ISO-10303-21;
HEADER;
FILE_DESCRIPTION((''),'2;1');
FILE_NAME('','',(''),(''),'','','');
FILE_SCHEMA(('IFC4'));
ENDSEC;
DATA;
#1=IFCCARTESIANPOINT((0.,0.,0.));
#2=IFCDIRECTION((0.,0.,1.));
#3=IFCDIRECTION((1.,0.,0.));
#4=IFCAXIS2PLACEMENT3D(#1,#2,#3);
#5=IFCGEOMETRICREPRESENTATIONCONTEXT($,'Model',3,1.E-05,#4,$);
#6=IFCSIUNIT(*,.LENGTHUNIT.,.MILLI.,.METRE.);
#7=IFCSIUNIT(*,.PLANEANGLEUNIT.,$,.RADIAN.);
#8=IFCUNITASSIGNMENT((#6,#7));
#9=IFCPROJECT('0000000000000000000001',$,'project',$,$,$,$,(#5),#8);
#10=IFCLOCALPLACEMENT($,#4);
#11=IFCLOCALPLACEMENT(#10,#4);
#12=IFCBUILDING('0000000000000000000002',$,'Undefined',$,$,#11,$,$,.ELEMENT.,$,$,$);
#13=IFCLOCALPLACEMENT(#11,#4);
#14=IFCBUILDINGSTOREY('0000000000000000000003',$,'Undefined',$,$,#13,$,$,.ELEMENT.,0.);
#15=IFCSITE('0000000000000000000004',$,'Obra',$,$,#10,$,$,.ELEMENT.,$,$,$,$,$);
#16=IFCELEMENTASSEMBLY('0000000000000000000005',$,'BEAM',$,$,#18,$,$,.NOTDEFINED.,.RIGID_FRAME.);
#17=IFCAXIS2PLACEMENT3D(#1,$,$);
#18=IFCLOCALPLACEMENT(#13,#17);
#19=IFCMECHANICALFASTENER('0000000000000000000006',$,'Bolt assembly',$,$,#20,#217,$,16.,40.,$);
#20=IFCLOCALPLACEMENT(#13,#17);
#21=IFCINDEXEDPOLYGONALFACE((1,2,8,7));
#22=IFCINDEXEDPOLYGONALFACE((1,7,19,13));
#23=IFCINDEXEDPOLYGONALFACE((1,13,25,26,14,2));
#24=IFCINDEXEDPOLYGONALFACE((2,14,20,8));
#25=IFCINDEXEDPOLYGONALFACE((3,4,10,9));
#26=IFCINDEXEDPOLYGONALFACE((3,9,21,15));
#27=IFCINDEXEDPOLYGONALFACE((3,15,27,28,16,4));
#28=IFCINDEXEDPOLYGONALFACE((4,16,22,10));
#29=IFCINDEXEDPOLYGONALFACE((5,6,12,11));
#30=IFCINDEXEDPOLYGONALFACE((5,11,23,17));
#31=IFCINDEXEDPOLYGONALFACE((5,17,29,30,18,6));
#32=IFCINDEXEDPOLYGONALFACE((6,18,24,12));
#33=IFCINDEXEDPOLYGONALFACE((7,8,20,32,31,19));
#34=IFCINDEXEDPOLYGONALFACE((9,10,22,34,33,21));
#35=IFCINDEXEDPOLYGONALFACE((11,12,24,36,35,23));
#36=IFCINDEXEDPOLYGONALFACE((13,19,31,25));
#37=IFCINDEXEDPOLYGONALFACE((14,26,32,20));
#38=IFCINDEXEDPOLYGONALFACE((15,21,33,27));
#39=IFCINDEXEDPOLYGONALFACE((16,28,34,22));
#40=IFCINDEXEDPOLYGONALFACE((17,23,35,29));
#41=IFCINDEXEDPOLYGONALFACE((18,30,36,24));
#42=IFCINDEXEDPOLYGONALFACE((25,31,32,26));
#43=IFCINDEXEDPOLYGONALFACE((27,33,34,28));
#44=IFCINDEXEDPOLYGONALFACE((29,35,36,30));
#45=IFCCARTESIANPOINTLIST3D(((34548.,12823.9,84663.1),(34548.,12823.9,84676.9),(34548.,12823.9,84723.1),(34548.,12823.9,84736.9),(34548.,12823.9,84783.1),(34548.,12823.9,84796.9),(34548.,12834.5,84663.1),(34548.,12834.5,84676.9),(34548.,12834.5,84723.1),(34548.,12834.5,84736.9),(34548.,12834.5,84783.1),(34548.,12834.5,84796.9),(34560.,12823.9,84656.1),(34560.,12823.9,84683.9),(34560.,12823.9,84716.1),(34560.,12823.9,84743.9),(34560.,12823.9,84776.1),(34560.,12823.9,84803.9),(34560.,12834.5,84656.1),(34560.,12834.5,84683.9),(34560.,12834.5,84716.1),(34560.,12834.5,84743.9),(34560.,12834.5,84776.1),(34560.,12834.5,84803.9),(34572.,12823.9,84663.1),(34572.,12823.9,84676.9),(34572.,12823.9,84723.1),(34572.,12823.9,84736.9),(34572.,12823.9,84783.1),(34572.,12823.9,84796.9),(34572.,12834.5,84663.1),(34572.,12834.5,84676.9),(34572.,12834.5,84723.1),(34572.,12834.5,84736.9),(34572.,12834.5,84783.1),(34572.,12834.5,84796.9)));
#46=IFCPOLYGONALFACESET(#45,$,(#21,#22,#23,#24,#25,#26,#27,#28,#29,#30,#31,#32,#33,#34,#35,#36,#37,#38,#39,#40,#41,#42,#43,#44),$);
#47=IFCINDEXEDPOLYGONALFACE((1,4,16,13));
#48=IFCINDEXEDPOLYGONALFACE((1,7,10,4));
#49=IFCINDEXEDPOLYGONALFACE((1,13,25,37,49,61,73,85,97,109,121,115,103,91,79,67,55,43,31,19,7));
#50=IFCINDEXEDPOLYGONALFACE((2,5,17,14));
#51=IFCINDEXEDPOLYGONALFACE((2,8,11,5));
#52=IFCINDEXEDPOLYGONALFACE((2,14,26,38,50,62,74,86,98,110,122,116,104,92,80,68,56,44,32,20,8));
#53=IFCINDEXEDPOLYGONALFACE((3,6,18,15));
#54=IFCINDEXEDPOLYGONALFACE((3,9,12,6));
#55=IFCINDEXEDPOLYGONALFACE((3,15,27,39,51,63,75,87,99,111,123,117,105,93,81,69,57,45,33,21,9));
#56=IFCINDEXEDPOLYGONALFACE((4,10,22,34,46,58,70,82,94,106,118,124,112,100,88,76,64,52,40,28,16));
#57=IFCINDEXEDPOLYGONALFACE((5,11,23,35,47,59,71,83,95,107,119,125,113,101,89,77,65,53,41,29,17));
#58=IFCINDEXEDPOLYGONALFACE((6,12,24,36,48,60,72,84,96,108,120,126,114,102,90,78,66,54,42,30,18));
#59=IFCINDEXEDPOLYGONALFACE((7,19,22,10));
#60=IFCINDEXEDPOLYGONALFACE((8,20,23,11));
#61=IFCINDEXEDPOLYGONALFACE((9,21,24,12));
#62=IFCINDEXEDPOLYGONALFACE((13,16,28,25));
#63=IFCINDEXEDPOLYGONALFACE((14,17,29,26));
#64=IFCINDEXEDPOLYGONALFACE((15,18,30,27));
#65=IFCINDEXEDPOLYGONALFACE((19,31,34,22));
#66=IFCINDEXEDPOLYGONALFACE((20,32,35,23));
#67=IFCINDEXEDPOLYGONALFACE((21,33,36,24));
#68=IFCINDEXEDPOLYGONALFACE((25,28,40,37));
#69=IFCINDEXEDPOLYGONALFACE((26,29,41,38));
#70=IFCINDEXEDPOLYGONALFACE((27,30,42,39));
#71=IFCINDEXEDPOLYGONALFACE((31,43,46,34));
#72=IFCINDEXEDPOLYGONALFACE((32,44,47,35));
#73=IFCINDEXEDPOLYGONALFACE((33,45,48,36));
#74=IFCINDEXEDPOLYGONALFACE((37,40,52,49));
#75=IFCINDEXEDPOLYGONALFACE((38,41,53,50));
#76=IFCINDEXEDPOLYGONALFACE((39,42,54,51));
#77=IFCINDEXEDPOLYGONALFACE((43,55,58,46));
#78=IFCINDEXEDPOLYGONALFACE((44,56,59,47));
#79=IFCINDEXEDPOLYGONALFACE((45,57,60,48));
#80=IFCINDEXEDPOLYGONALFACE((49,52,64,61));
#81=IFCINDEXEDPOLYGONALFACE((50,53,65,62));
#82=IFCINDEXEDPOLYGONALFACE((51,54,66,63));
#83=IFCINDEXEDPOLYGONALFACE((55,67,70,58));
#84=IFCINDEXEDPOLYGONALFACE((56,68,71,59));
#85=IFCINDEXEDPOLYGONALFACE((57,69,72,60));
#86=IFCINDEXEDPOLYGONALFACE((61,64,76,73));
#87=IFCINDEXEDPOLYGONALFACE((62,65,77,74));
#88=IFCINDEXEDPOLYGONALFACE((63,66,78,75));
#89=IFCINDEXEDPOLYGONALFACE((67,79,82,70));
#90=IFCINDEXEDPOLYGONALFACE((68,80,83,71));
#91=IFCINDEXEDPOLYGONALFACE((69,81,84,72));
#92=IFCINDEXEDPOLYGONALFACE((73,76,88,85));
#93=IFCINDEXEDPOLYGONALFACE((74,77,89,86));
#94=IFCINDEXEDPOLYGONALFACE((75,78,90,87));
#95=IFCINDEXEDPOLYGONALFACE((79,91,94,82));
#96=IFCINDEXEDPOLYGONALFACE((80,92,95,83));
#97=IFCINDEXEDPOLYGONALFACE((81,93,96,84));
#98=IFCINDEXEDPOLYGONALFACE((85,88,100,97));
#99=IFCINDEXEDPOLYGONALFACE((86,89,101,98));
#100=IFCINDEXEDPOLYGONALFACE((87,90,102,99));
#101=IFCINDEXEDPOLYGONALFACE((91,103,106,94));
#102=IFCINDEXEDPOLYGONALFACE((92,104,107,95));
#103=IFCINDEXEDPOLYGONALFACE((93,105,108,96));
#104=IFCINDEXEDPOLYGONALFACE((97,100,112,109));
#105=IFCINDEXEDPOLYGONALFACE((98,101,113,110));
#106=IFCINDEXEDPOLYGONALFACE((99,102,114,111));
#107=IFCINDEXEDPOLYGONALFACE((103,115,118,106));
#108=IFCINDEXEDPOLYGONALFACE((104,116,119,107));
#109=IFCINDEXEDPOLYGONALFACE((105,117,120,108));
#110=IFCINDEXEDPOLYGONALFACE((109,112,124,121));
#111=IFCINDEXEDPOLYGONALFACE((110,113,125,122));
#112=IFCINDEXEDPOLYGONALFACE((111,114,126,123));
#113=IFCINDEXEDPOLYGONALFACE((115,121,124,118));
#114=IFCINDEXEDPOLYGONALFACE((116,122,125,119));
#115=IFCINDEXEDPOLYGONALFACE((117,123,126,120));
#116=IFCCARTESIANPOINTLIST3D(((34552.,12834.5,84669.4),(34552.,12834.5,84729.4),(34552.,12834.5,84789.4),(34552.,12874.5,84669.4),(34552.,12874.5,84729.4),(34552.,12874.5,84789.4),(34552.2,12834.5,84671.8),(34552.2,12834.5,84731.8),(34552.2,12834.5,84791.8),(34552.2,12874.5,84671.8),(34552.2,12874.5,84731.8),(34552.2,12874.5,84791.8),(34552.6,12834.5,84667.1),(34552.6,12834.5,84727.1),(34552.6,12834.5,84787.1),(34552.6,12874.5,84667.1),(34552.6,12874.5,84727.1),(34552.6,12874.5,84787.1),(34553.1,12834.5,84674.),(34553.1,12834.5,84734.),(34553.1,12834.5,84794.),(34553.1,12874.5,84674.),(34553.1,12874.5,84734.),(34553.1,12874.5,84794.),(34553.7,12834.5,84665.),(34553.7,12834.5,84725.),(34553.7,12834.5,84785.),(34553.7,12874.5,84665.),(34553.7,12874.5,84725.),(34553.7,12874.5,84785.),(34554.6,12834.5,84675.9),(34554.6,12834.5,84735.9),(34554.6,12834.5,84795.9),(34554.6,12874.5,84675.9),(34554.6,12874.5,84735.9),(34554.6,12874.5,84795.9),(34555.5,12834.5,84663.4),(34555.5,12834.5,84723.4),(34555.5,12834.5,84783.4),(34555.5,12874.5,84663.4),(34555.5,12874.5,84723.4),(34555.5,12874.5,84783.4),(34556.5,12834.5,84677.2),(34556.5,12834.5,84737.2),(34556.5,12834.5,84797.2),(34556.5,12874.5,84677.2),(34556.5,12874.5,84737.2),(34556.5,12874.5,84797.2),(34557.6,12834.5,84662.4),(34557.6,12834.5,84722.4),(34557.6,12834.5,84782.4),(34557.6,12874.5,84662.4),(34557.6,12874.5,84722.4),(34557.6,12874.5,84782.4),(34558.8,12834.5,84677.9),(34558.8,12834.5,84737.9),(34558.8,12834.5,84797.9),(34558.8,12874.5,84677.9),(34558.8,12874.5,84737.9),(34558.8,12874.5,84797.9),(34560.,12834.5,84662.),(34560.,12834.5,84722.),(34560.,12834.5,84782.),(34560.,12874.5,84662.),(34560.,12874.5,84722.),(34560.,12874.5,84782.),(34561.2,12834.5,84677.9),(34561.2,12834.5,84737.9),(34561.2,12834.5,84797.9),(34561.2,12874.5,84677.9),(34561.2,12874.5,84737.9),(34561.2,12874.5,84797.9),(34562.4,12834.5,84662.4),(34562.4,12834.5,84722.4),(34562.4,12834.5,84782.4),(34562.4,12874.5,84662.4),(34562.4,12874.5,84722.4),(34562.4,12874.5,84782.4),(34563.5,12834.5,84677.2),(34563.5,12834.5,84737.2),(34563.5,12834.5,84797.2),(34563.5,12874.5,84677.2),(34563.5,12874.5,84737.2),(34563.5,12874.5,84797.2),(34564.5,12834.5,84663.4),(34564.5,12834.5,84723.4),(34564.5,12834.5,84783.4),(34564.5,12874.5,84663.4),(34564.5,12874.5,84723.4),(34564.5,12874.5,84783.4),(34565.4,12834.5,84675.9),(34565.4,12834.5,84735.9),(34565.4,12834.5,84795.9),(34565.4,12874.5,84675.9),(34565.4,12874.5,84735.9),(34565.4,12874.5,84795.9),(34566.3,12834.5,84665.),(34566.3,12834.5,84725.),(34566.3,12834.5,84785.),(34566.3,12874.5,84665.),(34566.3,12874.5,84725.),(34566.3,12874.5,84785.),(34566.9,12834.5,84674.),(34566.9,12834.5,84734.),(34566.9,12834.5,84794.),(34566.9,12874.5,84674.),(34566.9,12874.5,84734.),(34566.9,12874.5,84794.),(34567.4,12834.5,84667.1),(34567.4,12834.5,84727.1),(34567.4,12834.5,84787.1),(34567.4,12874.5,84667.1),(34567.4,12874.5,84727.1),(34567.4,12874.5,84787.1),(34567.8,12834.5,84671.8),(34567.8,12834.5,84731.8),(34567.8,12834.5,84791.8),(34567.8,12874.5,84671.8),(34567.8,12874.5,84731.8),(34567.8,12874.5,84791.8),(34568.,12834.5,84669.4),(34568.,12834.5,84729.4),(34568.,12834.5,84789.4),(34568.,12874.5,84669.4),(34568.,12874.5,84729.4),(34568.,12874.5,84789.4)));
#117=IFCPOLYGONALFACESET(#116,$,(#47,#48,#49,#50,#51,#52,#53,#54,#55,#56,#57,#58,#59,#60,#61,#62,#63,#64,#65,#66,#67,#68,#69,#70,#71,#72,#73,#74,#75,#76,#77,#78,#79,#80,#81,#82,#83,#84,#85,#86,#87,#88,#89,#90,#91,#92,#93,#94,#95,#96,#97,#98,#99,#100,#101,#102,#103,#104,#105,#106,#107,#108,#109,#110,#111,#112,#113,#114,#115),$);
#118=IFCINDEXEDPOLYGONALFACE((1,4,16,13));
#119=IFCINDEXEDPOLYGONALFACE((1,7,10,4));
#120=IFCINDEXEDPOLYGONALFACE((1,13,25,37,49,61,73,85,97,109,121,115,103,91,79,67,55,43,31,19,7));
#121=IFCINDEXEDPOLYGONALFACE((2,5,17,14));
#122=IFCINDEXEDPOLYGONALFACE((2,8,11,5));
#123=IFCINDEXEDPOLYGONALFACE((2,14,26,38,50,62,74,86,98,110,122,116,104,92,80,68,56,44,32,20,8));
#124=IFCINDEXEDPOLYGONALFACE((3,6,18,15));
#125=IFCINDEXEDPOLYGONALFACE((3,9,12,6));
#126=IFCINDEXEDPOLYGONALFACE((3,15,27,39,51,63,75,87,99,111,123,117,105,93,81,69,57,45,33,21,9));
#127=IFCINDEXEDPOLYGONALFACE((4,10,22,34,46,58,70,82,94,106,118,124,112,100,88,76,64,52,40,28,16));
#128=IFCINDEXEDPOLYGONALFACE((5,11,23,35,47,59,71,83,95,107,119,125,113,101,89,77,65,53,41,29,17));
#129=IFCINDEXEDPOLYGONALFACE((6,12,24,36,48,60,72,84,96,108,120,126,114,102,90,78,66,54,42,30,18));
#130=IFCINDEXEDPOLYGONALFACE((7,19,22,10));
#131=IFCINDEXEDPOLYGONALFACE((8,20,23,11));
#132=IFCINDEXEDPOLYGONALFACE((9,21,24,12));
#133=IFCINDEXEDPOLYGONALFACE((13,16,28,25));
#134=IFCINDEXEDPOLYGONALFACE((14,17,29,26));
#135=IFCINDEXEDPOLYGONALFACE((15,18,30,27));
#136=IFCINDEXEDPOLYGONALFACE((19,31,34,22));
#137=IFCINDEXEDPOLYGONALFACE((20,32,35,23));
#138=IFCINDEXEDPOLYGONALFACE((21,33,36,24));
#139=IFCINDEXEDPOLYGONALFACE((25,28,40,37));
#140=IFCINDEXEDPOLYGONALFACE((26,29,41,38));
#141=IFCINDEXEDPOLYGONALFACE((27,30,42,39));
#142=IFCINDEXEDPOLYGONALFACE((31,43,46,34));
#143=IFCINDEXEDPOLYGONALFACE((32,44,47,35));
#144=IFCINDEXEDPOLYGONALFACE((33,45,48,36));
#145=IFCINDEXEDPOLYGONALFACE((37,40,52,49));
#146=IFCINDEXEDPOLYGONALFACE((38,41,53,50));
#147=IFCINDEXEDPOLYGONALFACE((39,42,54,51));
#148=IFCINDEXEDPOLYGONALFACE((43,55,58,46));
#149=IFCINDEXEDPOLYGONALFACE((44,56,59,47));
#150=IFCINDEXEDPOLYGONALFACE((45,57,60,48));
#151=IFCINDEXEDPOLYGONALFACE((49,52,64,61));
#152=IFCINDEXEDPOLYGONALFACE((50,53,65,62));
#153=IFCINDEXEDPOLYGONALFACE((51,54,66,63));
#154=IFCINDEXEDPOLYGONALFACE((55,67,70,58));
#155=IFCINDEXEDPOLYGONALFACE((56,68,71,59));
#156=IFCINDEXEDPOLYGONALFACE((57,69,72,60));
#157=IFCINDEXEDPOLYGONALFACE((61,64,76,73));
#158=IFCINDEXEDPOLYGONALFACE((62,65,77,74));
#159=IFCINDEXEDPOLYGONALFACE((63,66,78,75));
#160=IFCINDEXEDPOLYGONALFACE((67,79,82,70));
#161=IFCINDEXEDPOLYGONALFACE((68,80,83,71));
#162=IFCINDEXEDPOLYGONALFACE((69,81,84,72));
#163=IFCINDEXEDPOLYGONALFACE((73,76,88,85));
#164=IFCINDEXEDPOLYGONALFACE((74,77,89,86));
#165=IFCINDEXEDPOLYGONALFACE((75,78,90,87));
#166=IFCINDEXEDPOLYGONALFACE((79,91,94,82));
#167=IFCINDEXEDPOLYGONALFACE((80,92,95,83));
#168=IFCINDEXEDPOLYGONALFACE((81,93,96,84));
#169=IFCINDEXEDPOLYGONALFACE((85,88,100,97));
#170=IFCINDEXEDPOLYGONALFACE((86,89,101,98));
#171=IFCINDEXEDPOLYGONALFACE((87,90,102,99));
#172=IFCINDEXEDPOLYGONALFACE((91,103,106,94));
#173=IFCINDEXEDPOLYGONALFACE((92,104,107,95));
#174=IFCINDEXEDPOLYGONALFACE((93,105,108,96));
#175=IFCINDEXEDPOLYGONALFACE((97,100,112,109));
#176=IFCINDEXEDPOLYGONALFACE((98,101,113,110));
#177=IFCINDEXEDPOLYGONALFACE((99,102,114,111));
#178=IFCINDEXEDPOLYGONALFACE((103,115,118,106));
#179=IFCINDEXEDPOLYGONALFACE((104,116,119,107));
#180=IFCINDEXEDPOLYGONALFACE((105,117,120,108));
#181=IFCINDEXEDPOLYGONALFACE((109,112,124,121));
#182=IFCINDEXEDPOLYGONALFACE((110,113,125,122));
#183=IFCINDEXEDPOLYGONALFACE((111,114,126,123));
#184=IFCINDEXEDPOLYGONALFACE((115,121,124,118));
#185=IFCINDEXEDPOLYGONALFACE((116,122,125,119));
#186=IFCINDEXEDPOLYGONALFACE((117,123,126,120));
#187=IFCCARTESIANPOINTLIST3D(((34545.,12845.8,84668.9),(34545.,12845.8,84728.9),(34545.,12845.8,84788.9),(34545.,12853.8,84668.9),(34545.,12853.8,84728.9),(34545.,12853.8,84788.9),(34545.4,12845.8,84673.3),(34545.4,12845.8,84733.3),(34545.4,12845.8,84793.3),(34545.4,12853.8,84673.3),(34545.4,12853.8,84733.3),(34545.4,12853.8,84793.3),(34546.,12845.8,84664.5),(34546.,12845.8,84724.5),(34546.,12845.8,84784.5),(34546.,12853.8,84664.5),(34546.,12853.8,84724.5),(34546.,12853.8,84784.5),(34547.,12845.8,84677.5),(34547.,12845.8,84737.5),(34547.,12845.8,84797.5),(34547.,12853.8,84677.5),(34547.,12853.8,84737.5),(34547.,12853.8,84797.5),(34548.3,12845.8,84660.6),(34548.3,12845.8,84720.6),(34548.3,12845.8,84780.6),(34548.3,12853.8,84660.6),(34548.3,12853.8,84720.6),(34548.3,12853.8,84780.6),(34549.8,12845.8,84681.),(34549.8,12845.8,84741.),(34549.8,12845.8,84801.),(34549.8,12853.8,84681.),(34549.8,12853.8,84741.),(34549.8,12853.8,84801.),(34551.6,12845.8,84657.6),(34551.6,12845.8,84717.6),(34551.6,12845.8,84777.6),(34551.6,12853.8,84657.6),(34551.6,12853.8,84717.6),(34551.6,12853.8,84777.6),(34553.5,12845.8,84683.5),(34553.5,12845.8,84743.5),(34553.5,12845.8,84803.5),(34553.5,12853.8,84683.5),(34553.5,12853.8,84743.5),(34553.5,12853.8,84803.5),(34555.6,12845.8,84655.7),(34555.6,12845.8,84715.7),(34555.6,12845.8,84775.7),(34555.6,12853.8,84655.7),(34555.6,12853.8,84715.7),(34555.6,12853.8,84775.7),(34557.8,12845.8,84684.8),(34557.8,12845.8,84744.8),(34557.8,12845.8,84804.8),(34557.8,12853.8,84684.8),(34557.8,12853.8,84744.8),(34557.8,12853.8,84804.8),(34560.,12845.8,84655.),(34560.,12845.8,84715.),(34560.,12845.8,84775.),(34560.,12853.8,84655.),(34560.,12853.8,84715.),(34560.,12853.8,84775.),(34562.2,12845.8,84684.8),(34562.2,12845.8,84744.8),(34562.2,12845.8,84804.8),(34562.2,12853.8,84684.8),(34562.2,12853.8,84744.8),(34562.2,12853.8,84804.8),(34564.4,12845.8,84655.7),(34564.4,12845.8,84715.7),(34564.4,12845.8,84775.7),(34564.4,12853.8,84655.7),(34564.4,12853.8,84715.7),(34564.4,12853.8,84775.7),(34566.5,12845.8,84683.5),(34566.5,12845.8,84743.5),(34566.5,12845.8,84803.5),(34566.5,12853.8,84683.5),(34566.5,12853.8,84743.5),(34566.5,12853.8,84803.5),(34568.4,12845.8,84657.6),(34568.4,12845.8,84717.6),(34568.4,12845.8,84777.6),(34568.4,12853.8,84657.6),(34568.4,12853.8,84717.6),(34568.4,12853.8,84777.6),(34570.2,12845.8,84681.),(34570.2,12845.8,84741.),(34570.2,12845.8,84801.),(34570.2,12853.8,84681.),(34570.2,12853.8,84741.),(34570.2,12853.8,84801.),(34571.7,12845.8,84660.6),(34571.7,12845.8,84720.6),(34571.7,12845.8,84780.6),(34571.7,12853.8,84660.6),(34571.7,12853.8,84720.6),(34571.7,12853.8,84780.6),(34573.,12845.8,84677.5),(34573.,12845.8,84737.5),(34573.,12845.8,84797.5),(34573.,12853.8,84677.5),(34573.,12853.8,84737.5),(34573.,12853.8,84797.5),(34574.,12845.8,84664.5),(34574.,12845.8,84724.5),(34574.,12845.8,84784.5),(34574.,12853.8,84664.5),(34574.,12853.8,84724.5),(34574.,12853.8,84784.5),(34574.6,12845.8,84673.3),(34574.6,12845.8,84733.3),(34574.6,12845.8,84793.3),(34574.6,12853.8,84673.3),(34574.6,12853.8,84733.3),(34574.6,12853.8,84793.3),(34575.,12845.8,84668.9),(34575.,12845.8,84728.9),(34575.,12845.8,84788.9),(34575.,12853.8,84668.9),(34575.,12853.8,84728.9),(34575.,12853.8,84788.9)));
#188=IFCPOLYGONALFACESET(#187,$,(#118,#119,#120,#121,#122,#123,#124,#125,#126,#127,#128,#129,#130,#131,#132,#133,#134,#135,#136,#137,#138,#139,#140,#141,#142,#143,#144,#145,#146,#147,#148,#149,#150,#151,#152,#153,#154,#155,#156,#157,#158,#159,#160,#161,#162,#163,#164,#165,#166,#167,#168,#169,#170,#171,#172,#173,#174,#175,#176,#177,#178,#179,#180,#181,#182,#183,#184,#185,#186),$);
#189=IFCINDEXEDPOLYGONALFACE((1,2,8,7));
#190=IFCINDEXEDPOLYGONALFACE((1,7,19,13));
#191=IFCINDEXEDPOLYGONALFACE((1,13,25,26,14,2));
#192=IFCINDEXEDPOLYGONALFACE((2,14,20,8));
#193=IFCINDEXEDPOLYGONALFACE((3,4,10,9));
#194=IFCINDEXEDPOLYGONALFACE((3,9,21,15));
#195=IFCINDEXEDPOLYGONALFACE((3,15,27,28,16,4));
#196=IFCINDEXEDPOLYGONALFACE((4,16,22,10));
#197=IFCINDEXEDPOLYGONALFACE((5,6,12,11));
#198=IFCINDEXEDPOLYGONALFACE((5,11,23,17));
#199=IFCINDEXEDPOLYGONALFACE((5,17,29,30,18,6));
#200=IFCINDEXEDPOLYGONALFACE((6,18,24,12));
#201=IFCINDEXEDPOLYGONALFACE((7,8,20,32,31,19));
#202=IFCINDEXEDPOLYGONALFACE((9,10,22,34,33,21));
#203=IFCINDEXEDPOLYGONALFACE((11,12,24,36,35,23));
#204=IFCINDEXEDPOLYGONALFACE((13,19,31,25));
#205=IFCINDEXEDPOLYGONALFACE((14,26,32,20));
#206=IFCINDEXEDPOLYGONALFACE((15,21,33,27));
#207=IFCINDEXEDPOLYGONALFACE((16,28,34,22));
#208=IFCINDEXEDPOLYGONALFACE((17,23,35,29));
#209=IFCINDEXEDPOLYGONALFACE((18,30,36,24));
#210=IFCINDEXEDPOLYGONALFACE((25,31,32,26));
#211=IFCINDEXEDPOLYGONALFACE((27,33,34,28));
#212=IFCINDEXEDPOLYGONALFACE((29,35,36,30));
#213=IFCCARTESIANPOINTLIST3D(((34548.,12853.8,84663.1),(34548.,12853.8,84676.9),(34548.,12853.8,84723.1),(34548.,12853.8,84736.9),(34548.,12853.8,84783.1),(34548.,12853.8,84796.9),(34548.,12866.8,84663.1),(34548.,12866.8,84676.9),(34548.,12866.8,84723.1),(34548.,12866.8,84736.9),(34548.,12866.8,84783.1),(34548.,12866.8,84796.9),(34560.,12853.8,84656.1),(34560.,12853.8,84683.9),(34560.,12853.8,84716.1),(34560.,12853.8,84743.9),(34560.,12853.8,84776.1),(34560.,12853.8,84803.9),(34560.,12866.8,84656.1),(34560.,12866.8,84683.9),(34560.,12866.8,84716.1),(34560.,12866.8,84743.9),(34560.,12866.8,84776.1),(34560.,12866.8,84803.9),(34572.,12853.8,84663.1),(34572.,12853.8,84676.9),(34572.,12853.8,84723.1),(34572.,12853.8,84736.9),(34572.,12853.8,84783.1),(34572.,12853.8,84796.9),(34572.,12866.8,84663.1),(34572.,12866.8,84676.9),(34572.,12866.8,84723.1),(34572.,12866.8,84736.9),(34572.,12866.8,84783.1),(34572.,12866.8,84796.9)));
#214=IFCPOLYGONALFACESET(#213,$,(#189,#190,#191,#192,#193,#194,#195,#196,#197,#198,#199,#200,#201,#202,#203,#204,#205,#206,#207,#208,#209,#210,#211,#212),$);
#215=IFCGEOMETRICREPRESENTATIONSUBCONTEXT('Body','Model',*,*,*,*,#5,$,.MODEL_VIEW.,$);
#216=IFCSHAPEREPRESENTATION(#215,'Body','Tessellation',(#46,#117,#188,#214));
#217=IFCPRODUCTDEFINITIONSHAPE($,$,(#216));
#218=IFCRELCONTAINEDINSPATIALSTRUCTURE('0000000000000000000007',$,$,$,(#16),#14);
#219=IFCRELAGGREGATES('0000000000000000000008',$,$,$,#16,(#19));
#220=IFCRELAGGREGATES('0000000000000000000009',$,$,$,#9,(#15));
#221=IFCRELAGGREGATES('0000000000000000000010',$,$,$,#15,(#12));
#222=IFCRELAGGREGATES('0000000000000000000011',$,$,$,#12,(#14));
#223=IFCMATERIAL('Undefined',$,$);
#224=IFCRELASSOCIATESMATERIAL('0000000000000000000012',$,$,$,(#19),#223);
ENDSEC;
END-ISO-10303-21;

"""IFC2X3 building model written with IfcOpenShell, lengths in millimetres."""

from ifc_helpers import new_model, si_unit, frame, origin_with_axes, origin_2d_with_axis, place, context, subcontext, project, spatial, polyline, circle, outline, extrude, source, transform, mapped, material, element, aggregate, save


model = new_model("IFC2X3")

# Units and contexts
model_context = context("Model", 3, precision=1e-05, world=origin_with_axes())
body_context = subcontext(model_context, "Body", "Model", "MODEL_VIEW")
ifc_project = project(units=[si_unit("LENGTHUNIT", "METRE", prefix="MILLI"), si_unit("PLANEANGLEUNIT", "RADIAN")], contexts=[model_context])

# Site, building, storey
site_placement = place(None, origin_with_axes())
site = spatial("IfcSite", under=ifc_project, at=site_placement, Name="Obra", CompositionType="ELEMENT")
building_placement = place(site_placement, origin_with_axes())
building = spatial("IfcBuilding", under=site, at=building_placement, Name="Undefined", CompositionType="ELEMENT")
storey_placement = place(building_placement, origin_with_axes())
storey = spatial("IfcBuildingStorey", under=building, at=storey_placement, Name="Undefined", CompositionType="ELEMENT", Elevation=0.0)

# Shared definitions
ifc_material_1 = material(Name="Undefined")

# Element assembly, mechanical fastener
assembly_1_placement = place(storey_placement, origin_with_axes())
assembly_1 = element("IfcElementAssembly", 1, at=assembly_1_placement, inside=storey, Name="BEAM", AssemblyPlace="NOTDEFINED", PredefinedType="RIGID_FRAME")
shared_shape_1 = source(origin_with_axes(), body_context, "Body", "SweptSolid", [
    extrude(outline(polyline([(13.9, 0.0), (6.9, 12.0), (-6.9, 12.0), (-13.9, 0.0), (-6.9, -12.0), (6.9, -12.0), (13.9, 0.0)])), frame((0.0, -19.7, 0.0), z_axis=(0.0, 1.0, 0.0), x_axis=(1.0, 0.0, 0.0)), (0.0, 0.0, 1.0), 10.6),
    extrude(circle(Radius=8.0, at=origin_2d_with_axis()), frame((0.0, -9.1, 0.0), z_axis=(0.0, 1.0, 0.0), x_axis=(1.0, 0.0, 0.0)), (0.0, 0.0, 1.0), 40.0),
    extrude(circle(Radius=15.0, at=origin_2d_with_axis()), frame((0.0, 2.2, 0.0), z_axis=(0.0, 1.0, 0.0), x_axis=(1.0, 0.0, 0.0)), (0.0, 0.0, 1.0), 8.0),
    extrude(outline(polyline([(13.9, 0.0), (6.9, 12.0), (-6.9, 12.0), (-13.9, 0.0), (-6.9, -12.0), (6.9, -12.0), (13.9, 0.0)])), frame((0.0, 10.2, 0.0), z_axis=(0.0, 1.0, 0.0), x_axis=(1.0, 0.0, 0.0)), (0.0, 0.0, 1.0), 13.0),
])
mechanical_fastener_1_placement = place(assembly_1_placement, frame((34510.0, 12843.6, 84850.0), z_axis=(1.0, 0.0, 0.0), x_axis=(0.0, 0.0, -1.0)))
mechanical_fastener_1 = element("IfcMechanicalFastener", 2, at=mechanical_fastener_1_placement, material=ifc_material_1, Name="Bolt assembly", NominalDiameter=16.0, NominalLength=40.0, context=body_context, shape_type="MappedRepresentation", body=[
    mapped(shared_shape_1, transform((60.0, 0.0, 50.0))),
    mapped(shared_shape_1, transform((120.0, 0.0, 50.0))),
    mapped(shared_shape_1, transform((180.0, 0.0, 50.0))),
])
aggregate(assembly_1, [mechanical_fastener_1])

save(model, "model.ifc")
